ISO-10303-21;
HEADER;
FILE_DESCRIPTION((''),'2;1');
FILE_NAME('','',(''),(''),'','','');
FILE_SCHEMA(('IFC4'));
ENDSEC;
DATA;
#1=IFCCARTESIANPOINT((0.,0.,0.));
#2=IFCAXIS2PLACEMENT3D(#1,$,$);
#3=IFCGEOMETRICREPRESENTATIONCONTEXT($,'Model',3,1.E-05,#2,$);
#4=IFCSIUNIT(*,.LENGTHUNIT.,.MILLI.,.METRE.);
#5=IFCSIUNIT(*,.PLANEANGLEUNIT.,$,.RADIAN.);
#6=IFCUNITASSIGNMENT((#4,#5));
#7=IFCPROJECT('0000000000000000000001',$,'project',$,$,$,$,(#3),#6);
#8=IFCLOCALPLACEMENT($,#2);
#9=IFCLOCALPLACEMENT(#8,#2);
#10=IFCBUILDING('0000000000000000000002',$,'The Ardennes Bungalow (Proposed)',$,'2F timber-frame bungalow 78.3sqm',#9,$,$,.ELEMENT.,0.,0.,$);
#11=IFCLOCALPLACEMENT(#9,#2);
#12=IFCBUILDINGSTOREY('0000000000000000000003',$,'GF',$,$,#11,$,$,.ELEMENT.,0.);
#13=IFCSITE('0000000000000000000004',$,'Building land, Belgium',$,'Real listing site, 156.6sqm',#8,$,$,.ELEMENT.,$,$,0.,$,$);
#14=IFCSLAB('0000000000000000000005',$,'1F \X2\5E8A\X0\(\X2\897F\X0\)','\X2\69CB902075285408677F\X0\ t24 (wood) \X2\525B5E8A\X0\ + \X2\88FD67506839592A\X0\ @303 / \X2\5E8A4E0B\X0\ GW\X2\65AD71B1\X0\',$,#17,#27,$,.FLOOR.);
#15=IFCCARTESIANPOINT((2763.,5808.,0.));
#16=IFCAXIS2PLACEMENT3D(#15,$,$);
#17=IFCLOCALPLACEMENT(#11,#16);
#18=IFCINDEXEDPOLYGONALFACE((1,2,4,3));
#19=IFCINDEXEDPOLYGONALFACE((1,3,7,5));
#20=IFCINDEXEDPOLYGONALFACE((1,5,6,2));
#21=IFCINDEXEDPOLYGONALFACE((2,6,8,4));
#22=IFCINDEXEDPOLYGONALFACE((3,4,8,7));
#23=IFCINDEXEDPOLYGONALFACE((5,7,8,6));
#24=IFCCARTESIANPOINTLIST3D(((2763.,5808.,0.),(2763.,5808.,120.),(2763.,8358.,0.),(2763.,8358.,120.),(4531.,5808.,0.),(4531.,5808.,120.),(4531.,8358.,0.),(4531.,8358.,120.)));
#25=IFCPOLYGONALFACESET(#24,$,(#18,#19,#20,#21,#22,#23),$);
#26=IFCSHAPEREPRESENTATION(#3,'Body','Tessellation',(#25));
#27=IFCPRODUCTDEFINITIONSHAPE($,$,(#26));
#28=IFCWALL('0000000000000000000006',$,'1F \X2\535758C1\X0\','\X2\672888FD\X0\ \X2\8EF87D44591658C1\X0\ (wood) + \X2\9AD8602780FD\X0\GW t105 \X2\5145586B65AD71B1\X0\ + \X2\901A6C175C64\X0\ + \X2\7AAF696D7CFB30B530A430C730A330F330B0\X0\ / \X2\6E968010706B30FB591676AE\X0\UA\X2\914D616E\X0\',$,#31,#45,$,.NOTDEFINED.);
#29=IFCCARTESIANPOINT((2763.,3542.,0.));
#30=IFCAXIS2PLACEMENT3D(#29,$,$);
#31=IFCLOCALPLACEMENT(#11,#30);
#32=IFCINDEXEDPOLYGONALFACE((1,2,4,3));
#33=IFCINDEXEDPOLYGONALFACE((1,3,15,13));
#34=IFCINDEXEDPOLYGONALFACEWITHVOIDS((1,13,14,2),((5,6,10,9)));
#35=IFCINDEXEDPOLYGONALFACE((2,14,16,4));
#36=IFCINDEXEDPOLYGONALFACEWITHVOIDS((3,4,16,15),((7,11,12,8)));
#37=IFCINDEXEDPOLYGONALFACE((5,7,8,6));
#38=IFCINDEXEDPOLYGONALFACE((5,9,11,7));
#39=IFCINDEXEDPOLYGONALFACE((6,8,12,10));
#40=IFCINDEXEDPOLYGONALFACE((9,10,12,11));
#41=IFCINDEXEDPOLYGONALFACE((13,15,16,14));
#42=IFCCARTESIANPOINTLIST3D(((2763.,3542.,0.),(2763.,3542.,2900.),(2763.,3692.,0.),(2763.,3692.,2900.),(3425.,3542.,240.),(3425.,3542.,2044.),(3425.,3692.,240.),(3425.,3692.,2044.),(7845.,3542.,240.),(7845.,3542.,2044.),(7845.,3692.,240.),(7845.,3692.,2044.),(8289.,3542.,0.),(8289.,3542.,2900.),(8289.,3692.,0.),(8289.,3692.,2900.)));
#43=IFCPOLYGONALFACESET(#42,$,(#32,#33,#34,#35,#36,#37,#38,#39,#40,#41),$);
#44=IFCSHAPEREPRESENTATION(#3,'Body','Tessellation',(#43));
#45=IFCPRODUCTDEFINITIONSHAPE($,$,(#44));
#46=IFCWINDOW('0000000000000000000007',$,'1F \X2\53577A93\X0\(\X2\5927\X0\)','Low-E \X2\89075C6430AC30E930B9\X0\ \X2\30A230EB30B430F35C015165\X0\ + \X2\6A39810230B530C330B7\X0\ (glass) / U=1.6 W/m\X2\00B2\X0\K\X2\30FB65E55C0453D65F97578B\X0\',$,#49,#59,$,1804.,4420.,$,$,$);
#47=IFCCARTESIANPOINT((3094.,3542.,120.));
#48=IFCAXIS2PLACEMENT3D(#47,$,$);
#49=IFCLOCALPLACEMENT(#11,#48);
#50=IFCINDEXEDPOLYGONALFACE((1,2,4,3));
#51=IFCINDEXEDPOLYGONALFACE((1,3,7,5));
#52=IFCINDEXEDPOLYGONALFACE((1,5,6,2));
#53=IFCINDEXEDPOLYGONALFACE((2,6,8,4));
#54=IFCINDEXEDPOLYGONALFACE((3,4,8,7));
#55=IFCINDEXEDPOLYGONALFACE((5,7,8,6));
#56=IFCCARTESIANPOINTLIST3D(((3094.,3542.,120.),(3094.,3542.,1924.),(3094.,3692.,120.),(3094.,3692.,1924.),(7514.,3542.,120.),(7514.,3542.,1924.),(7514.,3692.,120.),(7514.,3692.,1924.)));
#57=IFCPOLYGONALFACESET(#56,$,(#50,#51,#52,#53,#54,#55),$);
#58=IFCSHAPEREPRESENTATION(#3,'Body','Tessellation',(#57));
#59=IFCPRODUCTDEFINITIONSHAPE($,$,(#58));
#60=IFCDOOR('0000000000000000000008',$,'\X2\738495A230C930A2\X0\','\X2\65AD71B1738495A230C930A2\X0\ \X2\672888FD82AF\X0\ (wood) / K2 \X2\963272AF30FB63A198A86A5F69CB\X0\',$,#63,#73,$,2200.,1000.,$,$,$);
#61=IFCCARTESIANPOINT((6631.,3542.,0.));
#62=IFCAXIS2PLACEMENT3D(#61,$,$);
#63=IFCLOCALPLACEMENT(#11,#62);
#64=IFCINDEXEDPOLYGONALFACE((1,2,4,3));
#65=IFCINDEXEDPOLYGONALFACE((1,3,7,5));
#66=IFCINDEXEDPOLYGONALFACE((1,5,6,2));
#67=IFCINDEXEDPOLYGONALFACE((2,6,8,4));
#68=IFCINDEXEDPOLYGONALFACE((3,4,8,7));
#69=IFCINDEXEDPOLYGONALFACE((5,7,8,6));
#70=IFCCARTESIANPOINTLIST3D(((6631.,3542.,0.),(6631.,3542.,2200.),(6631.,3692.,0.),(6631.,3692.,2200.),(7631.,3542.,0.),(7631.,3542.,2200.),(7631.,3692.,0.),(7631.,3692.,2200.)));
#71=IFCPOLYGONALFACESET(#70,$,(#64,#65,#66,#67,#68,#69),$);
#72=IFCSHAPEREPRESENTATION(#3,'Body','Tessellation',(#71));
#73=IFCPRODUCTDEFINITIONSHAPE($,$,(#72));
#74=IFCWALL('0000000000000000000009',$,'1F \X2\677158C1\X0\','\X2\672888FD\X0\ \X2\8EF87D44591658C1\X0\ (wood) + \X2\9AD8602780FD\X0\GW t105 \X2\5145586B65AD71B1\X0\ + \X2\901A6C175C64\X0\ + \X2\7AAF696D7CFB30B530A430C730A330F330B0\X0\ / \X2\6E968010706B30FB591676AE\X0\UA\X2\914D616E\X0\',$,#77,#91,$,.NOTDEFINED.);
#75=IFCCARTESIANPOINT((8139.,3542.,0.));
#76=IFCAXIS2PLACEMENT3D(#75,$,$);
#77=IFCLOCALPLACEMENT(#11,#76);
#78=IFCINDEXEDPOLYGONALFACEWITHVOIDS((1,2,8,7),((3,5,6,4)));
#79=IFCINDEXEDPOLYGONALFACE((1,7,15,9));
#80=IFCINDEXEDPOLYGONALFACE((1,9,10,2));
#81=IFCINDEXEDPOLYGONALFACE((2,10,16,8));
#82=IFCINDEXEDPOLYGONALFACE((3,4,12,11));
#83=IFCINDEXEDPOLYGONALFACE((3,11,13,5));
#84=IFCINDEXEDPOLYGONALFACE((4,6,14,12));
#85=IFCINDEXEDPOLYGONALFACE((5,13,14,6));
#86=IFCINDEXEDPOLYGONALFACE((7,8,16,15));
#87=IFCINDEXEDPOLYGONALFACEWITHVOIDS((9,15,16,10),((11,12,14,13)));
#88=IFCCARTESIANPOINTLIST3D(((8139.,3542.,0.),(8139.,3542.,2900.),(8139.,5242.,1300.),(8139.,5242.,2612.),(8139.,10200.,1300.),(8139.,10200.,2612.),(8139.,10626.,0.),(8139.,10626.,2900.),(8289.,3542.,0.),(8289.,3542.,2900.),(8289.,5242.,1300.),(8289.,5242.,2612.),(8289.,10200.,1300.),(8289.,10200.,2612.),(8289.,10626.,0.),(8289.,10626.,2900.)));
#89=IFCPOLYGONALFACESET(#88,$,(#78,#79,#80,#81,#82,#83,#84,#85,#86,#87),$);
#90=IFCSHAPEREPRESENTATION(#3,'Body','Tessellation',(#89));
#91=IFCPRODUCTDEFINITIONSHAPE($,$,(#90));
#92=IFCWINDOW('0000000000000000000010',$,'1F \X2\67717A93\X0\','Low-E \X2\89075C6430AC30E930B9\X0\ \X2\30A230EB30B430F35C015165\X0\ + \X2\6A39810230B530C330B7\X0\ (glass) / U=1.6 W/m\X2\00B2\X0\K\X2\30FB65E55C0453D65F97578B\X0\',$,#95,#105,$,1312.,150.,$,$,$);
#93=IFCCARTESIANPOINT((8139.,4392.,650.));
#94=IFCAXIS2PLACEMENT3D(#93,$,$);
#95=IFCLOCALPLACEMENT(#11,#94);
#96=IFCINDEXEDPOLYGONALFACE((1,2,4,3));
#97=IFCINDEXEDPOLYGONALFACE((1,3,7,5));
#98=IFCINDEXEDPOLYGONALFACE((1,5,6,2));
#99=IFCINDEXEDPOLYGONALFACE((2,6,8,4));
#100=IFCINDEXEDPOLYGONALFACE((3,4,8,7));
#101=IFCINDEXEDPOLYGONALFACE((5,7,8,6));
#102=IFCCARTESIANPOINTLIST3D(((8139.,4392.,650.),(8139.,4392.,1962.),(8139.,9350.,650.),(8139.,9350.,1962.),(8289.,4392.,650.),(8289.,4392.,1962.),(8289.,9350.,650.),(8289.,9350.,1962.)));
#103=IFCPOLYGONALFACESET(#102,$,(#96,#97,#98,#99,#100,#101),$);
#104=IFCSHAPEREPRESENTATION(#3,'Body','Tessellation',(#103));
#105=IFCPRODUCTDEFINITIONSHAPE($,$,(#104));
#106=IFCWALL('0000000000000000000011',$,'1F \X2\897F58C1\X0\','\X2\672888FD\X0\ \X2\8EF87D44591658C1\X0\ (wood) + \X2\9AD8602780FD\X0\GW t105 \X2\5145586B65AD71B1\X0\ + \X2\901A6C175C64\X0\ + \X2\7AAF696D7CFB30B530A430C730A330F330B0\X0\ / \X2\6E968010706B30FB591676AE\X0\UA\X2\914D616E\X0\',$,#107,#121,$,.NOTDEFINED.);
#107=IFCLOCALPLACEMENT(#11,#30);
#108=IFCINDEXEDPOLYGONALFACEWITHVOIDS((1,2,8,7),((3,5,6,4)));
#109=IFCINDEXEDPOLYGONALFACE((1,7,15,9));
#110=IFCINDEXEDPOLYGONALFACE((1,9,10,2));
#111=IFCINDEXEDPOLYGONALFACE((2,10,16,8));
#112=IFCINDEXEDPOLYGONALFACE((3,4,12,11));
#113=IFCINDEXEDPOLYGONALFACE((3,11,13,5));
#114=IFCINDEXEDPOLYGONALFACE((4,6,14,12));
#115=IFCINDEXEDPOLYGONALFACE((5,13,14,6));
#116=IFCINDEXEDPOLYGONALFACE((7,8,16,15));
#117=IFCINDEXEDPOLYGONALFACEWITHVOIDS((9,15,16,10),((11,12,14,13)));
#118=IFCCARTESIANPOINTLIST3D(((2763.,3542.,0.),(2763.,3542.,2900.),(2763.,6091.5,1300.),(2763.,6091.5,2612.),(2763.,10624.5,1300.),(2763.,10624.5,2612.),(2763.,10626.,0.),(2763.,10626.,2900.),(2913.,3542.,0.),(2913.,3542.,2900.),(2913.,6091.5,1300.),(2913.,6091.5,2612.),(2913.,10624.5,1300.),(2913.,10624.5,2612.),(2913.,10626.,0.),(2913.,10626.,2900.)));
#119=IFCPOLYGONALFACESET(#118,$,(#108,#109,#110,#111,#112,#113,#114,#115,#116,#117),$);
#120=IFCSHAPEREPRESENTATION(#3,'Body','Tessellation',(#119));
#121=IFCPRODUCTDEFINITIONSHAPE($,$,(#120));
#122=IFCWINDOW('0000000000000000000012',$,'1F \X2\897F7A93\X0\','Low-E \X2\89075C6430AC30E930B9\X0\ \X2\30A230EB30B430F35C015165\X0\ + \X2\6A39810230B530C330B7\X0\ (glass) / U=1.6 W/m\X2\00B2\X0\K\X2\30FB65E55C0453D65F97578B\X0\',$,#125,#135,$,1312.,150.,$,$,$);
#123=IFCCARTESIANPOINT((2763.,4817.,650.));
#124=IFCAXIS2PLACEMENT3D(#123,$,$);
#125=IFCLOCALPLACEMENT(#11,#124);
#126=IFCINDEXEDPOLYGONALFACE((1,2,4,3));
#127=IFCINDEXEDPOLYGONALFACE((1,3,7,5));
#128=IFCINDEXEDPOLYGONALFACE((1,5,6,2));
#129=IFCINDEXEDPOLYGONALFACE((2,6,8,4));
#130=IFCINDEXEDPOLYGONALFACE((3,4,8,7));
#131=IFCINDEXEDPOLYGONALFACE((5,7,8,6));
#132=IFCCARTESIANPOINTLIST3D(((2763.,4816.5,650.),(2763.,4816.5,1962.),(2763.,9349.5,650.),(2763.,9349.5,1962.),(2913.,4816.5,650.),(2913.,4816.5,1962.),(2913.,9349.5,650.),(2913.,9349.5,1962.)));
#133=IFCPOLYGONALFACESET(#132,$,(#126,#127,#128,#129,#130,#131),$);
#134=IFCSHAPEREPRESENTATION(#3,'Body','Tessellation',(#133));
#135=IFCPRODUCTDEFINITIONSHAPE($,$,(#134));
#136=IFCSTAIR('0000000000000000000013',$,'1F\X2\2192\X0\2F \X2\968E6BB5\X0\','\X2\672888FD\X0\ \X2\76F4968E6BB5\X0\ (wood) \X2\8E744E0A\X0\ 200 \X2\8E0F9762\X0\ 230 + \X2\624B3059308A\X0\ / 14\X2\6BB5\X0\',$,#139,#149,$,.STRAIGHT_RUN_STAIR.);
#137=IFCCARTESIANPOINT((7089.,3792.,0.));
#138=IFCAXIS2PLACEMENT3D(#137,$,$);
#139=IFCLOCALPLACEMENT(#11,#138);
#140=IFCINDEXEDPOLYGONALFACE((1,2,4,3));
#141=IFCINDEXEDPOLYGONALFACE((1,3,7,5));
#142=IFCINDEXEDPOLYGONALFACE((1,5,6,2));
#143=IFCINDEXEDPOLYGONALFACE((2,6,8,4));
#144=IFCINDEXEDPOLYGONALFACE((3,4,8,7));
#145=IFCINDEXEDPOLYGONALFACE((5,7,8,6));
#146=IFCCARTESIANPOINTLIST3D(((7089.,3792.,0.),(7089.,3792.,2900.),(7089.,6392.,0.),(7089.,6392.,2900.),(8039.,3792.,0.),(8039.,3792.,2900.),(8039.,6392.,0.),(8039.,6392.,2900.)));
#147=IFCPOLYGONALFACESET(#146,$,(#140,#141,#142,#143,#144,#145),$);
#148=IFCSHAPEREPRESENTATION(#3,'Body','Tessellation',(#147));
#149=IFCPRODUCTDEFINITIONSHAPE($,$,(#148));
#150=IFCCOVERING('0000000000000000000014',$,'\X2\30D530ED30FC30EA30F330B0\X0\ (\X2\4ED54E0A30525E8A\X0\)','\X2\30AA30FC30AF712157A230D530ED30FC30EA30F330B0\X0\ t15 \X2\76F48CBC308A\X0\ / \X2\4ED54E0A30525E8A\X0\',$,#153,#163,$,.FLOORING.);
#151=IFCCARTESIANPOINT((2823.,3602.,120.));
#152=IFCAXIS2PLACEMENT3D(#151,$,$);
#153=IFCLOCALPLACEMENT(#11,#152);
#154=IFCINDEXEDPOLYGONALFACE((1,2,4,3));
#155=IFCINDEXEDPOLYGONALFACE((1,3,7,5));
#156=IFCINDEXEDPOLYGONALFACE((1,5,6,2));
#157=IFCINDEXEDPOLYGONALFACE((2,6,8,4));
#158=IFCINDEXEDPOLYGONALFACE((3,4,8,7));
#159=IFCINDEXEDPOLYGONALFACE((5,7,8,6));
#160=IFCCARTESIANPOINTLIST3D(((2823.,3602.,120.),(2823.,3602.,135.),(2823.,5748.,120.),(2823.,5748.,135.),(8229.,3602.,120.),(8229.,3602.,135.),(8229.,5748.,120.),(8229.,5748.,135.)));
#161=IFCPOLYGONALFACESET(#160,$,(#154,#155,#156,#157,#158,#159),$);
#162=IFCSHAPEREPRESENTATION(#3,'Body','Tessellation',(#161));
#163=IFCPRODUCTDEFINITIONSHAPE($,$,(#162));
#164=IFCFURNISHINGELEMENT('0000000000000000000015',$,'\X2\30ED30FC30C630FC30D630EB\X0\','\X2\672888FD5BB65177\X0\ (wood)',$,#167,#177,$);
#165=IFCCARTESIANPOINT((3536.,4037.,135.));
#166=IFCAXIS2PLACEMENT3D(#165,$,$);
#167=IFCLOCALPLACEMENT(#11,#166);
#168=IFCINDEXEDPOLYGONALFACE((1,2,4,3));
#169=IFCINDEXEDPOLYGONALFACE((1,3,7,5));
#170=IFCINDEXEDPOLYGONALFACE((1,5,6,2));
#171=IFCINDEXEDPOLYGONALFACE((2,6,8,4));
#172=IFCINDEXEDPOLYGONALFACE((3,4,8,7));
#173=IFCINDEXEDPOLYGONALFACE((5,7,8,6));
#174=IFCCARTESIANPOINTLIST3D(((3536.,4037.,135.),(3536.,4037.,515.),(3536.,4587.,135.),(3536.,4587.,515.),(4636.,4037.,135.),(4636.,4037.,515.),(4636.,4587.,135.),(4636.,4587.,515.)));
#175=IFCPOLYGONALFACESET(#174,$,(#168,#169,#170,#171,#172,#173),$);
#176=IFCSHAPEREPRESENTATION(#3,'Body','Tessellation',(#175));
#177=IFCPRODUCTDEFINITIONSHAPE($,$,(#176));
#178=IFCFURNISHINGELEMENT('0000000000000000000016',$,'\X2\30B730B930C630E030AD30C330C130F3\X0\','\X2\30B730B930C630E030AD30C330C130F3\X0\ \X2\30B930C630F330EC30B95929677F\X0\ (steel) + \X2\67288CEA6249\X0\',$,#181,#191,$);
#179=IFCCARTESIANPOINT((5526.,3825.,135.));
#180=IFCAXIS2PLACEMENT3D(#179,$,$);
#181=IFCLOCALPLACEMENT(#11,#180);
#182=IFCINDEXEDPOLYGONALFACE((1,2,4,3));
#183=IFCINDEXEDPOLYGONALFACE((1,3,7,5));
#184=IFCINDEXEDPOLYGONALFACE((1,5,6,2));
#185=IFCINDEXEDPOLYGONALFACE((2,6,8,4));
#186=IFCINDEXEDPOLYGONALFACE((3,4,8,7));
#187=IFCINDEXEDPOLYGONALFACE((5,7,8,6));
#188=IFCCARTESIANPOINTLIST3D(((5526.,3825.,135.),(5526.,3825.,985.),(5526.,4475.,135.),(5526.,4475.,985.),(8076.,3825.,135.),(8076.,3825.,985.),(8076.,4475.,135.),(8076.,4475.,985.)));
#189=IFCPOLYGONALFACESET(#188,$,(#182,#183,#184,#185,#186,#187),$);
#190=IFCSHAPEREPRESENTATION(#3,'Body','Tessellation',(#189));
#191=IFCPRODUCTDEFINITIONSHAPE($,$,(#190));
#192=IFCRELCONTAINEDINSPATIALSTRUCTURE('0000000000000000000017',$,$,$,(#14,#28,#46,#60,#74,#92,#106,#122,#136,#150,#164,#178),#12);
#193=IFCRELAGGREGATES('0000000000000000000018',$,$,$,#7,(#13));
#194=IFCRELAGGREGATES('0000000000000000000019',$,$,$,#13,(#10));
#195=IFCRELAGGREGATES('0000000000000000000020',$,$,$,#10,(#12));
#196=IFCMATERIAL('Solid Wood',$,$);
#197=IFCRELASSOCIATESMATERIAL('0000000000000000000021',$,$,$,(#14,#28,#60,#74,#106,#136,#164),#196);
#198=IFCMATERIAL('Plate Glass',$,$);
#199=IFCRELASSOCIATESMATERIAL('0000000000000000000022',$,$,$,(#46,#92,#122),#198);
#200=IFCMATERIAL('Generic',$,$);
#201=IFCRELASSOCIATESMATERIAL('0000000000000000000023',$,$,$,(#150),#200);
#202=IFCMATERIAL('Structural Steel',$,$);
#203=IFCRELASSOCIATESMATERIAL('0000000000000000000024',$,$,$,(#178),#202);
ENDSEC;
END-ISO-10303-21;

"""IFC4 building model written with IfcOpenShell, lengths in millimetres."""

from ifc_helpers import new_model, si_unit, frame, frame_2d, origin, place, context, project, spatial, rectangle, extrude, material, element, fill, save


model = new_model("IFC4")

# Units and contexts
model_context = context("Model", 3, precision=1e-05, world=origin())
ifc_project = project(units=[si_unit("LENGTHUNIT", "METRE", prefix="MILLI"), si_unit("PLANEANGLEUNIT", "RADIAN")], contexts=[model_context])

# Site, building, storey
site_placement = place(None, origin())
site = spatial("IfcSite", under=ifc_project, at=site_placement, Name="Building land, Belgium", ObjectType="Real listing site, 156.6sqm", CompositionType="ELEMENT", RefElevation=0.0)
building_placement = place(site_placement, origin())
building = spatial("IfcBuilding", under=site, at=building_placement, Name="The Ardennes Bungalow (Proposed)", ObjectType="2F timber-frame bungalow 78.3sqm", CompositionType="ELEMENT", ElevationOfRefHeight=0.0, ElevationOfTerrain=0.0)
storey_placement = place(building_placement, origin())
storey = spatial("IfcBuildingStorey", under=building, at=storey_placement, Name="GF", CompositionType="ELEMENT", Elevation=0.0)

# Slab
ifc_material_1 = material(Name="Solid Wood")
slab_1_placement = place(storey_placement, frame((2763.0, 5808.0, 0.0)))
element("IfcSlab", 1, at=slab_1_placement, inside=storey, material=ifc_material_1, Name="1F 床(西)", Description="構造用合板 t24 (wood) 剛床 + 製材根太 @303 / 床下 GW断熱", PredefinedType="FLOOR", context=model_context, shape_type="SweptSolid", body=[
    extrude(rectangle(XDim=1768.0, YDim=2550.0, at=frame_2d((884.0, 1275.0))), frame((2763.0, 5808.0, 0.0)), (0.0, 0.0, 1.0), 120.0),
])

# Wall, openings, window, door
wall_1_placement = place(storey_placement, frame((2763.0, 3542.0, 0.0)))
wall_1 = element("IfcWall", 2, at=wall_1_placement, inside=storey, material=ifc_material_1, Name="1F 南壁", Description="木製 軸組外壁 (wood) + 高性能GW t105 充填断熱 + 通気層 + 窯業系サイディング / 準耐火・外皮UA配慮", PredefinedType="NOTDEFINED", context=model_context, shape_type="SweptSolid", body=[
    extrude(rectangle(XDim=5526.0, YDim=150.0, at=frame_2d((2763.0, 75.0))), frame((2763.0, 3542.0, 0.0)), (0.0, 0.0, 1.0), 2900.0),
])
opening_1_placement = place(storey_placement, frame((3094.0, 3542.0, 120.0)))
opening_1 = element("IfcOpeningElement", 3, at=opening_1_placement, cuts=wall_1, PredefinedType="NOTDEFINED", context=model_context, shape_type="SweptSolid", body=[
    extrude(rectangle(XDim=4420.0, YDim=150.0, at=frame_2d((2210.0, 75.0))), frame((3094.0, 3542.0, 120.0)), (0.0, 0.0, 1.0), 1804.0),
])
opening_2_placement = place(storey_placement, frame((6631.0, 3542.0, 0.0)))
opening_2 = element("IfcOpeningElement", 4, at=opening_2_placement, cuts=wall_1, PredefinedType="NOTDEFINED", context=model_context, shape_type="SweptSolid", body=[
    extrude(rectangle(XDim=1000.0, YDim=150.0, at=frame_2d((500.0, 75.0))), frame((6631.0, 3542.0, 0.0)), (0.0, 0.0, 1.0), 2200.0),
])
ifc_material_2 = material(Name="Plate Glass")
window_1_placement = place(storey_placement, frame((3094.0, 3542.0, 120.0)))
window_1 = element("IfcWindow", 5, at=window_1_placement, inside=storey, material=ifc_material_2, Name="1F 南窓(大)", Description="Low-E 複層ガラス アルゴン封入 + 樹脂サッシ (glass) / U=1.6 W/m²K・日射取得型", OverallHeight=1804.0, OverallWidth=4420.0, context=model_context, shape_type="SweptSolid", body=[
    extrude(rectangle(XDim=4420.0, YDim=150.0, at=frame_2d((2210.0, 75.0))), frame((3094.0, 3542.0, 120.0)), (0.0, 0.0, 1.0), 1804.0),
])
fill(opening_1, window_1)
door_placement = place(storey_placement, frame((6631.0, 3542.0, 0.0)))
door = element("IfcDoor", 6, at=door_placement, inside=storey, material=ifc_material_1, Name="玄関ドア", Description="断熱玄関ドア 木製芯 (wood) / K2 防犯・採風機構", OverallHeight=2200.0, OverallWidth=1000.0, context=model_context, shape_type="SweptSolid", body=[
    extrude(rectangle(XDim=1000.0, YDim=150.0, at=frame_2d((500.0, 75.0))), frame((6631.0, 3542.0, 0.0)), (0.0, 0.0, 1.0), 2200.0),
])
fill(opening_2, door)

# Walls, openings, windows
wall_2_placement = place(storey_placement, frame((8139.0, 3542.0, 0.0)))
wall_2 = element("IfcWall", 7, at=wall_2_placement, inside=storey, material=ifc_material_1, Name="1F 東壁", Description="木製 軸組外壁 (wood) + 高性能GW t105 充填断熱 + 通気層 + 窯業系サイディング / 準耐火・外皮UA配慮", PredefinedType="NOTDEFINED", context=model_context, shape_type="SweptSolid", body=[
    extrude(rectangle(XDim=150.0, YDim=7084.0, at=frame_2d((75.0, 3542.0))), frame((8139.0, 3542.0, 0.0)), (0.0, 0.0, 1.0), 2900.0),
])
opening_3_placement = place(storey_placement, frame((8139.0, 4392.0, 650.0)))
opening_3 = element("IfcOpeningElement", 8, at=opening_3_placement, cuts=wall_2, PredefinedType="NOTDEFINED", context=model_context, shape_type="SweptSolid", body=[
    extrude(rectangle(XDim=150.0, YDim=4958.0, at=frame_2d((75.0, 2479.0))), frame((8139.0, 4392.0, 650.0)), (0.0, 0.0, 1.0), 1312.0),
])
window_2_placement = place(storey_placement, frame((8139.0, 4392.0, 650.0)))
window_2 = element("IfcWindow", 9, at=window_2_placement, inside=storey, material=ifc_material_2, Name="1F 東窓", Description="Low-E 複層ガラス アルゴン封入 + 樹脂サッシ (glass) / U=1.6 W/m²K・日射取得型", OverallHeight=1312.0, OverallWidth=150.0, context=model_context, shape_type="SweptSolid", body=[
    extrude(rectangle(XDim=150.0, YDim=4958.0, at=frame_2d((75.0, 2479.0))), frame((8139.0, 4392.0, 650.0)), (0.0, 0.0, 1.0), 1312.0),
])
fill(opening_3, window_2)
wall_3_placement = place(storey_placement, frame((2763.0, 3542.0, 0.0)))
wall_3 = element("IfcWall", 10, at=wall_3_placement, inside=storey, material=ifc_material_1, Name="1F 西壁", Description="木製 軸組外壁 (wood) + 高性能GW t105 充填断熱 + 通気層 + 窯業系サイディング / 準耐火・外皮UA配慮", PredefinedType="NOTDEFINED", context=model_context, shape_type="SweptSolid", body=[
    extrude(rectangle(XDim=150.0, YDim=7084.0, at=frame_2d((75.0, 3542.0))), frame((2763.0, 3542.0, 0.0)), (0.0, 0.0, 1.0), 2900.0),
])
opening_4_placement = place(storey_placement, frame((2763.0, 4817.0, 650.0)))
opening_4 = element("IfcOpeningElement", 11, at=opening_4_placement, cuts=wall_3, PredefinedType="NOTDEFINED", context=model_context, shape_type="SweptSolid", body=[
    extrude(rectangle(XDim=150.0, YDim=4533.0, at=frame_2d((75.0, 2266.0))), frame((2763.0, 4817.0, 650.0)), (0.0, 0.0, 1.0), 1312.0),
])
window_3_placement = place(storey_placement, frame((2763.0, 4817.0, 650.0)))
window_3 = element("IfcWindow", 12, at=window_3_placement, inside=storey, material=ifc_material_2, Name="1F 西窓", Description="Low-E 複層ガラス アルゴン封入 + 樹脂サッシ (glass) / U=1.6 W/m²K・日射取得型", OverallHeight=1312.0, OverallWidth=150.0, context=model_context, shape_type="SweptSolid", body=[
    extrude(rectangle(XDim=150.0, YDim=4533.0, at=frame_2d((75.0, 2266.0))), frame((2763.0, 4817.0, 650.0)), (0.0, 0.0, 1.0), 1312.0),
])
fill(opening_4, window_3)

# Stair
stair_placement = place(storey_placement, frame((7089.0, 3792.0, 0.0)))
element("IfcStair", 13, at=stair_placement, inside=storey, material=ifc_material_1, Name="1F→2F 階段", Description="木製 直階段 (wood) 蹴上 200 踏面 230 + 手すり / 14段", PredefinedType="STRAIGHT_RUN_STAIR", context=model_context, shape_type="SweptSolid", body=[
    extrude(rectangle(XDim=950.0, YDim=2600.0, at=frame_2d((475.0, 1300.0))), frame((7089.0, 3792.0, 0.0)), (0.0, 0.0, 1.0), 2900.0),
])

# Covering
ifc_material_3 = material(Name="Generic")
covering_placement = place(storey_placement, frame((2823.0, 3602.0, 120.0)))
element("IfcCovering", 14, at=covering_placement, inside=storey, material=ifc_material_3, Name="フローリング (仕上げ床)", Description="オーク無垢フローリング t15 直貼り / 仕上げ床", PredefinedType="FLOORING", context=model_context, shape_type="SweptSolid", body=[
    extrude(rectangle(XDim=5406.0, YDim=2146.0, at=frame_2d((2703.0, 1073.0))), frame((2823.0, 3602.0, 120.0)), (0.0, 0.0, 1.0), 15.0),
])

# Furnishing elements
furnishing_1_placement = place(storey_placement, frame((3536.0, 4037.0, 135.0)))
element("IfcFurnishingElement", 15, at=furnishing_1_placement, inside=storey, material=ifc_material_1, Name="ローテーブル", Description="木製家具 (wood)", context=model_context, shape_type="SweptSolid", body=[
    extrude(rectangle(XDim=1100.0, YDim=550.0, at=frame_2d((550.0, 275.0))), frame((3536.0, 4037.0, 135.0)), (0.0, 0.0, 1.0), 380.0),
])
ifc_material_4 = material(Name="Structural Steel")
furnishing_2_placement = place(storey_placement, frame((5526.0, 3825.0, 135.0)))
element("IfcFurnishingElement", 16, at=furnishing_2_placement, inside=storey, material=ifc_material_4, Name="システムキッチン", Description="システムキッチン ステンレス天板 (steel) + 木質扉", context=model_context, shape_type="SweptSolid", body=[
    extrude(rectangle(XDim=2550.0, YDim=650.0, at=frame_2d((1275.0, 325.0))), frame((5526.0, 3825.0, 135.0)), (0.0, 0.0, 1.0), 850.0),
])

save(model, "model.ifc")
